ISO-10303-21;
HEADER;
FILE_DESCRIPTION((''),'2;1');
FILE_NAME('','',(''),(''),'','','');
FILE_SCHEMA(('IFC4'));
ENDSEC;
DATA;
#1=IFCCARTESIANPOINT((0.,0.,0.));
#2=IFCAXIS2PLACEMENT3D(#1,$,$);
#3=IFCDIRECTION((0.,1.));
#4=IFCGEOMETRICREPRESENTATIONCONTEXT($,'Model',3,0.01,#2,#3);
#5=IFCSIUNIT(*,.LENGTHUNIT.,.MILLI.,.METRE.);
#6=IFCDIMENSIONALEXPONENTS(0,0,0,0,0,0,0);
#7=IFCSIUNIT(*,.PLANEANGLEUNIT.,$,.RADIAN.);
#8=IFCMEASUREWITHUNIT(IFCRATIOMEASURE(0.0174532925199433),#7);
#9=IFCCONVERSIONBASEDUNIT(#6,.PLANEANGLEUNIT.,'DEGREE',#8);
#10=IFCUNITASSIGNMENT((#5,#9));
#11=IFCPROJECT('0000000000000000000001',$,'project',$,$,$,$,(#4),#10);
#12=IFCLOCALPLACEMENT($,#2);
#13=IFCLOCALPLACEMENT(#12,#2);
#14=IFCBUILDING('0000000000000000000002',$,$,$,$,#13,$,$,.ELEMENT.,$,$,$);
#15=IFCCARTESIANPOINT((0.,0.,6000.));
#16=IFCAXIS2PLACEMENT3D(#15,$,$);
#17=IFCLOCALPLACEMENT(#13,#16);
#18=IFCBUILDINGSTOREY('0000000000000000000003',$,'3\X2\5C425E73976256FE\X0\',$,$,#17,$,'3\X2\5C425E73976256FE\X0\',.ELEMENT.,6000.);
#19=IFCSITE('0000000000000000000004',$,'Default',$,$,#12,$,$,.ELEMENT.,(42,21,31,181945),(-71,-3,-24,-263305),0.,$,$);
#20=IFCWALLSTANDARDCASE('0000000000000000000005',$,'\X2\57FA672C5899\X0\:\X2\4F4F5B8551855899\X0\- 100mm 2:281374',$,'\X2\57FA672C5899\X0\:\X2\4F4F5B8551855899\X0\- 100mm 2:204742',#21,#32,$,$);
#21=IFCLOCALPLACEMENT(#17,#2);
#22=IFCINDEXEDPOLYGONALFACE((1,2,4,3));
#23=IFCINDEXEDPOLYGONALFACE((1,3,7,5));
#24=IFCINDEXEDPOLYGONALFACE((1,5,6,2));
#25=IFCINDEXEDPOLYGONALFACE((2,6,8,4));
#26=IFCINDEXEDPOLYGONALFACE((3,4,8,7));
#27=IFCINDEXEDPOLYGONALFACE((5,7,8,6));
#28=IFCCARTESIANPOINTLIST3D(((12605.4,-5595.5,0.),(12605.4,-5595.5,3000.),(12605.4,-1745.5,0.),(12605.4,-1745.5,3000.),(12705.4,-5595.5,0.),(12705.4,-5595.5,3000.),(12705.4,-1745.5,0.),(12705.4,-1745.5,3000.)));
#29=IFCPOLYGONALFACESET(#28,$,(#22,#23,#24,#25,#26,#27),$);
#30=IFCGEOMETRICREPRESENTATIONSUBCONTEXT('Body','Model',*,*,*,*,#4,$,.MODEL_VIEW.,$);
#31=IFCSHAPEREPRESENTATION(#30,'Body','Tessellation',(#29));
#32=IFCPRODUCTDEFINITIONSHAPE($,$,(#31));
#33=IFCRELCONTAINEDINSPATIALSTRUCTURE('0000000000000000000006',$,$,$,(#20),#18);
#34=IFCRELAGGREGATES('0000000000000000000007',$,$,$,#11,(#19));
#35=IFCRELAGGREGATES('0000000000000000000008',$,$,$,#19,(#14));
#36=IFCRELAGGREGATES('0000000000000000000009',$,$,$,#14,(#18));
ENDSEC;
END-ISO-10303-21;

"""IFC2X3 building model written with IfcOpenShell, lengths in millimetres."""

from ifc_helpers import new_model, entity, si_unit, converted_unit, direction, frame, frame_2d, origin, place, context, subcontext, project, spatial, rectangle, extrude, element, save


model = new_model("IFC2X3")

# Units and contexts
model_context = context("Model", 3, precision=0.01, world=origin(), true_north=direction((0.0, 1.0)))
body_context = subcontext(model_context, "Body", "Model", "MODEL_VIEW")
ifc_project = project(units=[si_unit("LENGTHUNIT", "METRE", prefix="MILLI"), converted_unit("PLANEANGLEUNIT", "DEGREE", entity("IfcRatioMeasure", 0.0174532925199433), si_unit("PLANEANGLEUNIT", "RADIAN"), dimensions=[0, 0, 0, 0, 0, 0, 0])], contexts=[model_context])

# Site, building, storey
site_placement = place(None, origin())
site = spatial("IfcSite", under=ifc_project, at=site_placement, Name="Default", CompositionType="ELEMENT", RefLatitude=(42, 21, 31, 181945), RefLongitude=(-71, -3, -24, -263305), RefElevation=0.0)
building_placement = place(site_placement, origin())
building = spatial("IfcBuilding", under=site, at=building_placement, CompositionType="ELEMENT")
storey_placement = place(building_placement, frame((0.0, 0.0, 6000.0)))
storey = spatial("IfcBuildingStorey", under=building, at=storey_placement, Name="3层平面图", LongName="3层平面图", CompositionType="ELEMENT", Elevation=6000.0)

# Wall
wall_1_placement = place(storey_placement, frame((12655.4, -1745.5, 0.0), z_axis=(0.0, 0.0, 1.0), x_axis=(0.0, -1.0, 0.0)))
element("IfcWallStandardCase", 1, at=wall_1_placement, inside=storey, Name="基本墙:住宅内墙- 100mm 2:281374", ObjectType="基本墙:住宅内墙- 100mm 2:204742", context=body_context, shape_type="SweptSolid", body=[
    extrude(rectangle(XDim=3850.0, YDim=100.0, at=frame_2d((1925.0, 0.0), x_axis=(-1.0, 0.0))), origin(), (0.0, 0.0, 1.0), 3000.0),
])

save(model, "model.ifc")
